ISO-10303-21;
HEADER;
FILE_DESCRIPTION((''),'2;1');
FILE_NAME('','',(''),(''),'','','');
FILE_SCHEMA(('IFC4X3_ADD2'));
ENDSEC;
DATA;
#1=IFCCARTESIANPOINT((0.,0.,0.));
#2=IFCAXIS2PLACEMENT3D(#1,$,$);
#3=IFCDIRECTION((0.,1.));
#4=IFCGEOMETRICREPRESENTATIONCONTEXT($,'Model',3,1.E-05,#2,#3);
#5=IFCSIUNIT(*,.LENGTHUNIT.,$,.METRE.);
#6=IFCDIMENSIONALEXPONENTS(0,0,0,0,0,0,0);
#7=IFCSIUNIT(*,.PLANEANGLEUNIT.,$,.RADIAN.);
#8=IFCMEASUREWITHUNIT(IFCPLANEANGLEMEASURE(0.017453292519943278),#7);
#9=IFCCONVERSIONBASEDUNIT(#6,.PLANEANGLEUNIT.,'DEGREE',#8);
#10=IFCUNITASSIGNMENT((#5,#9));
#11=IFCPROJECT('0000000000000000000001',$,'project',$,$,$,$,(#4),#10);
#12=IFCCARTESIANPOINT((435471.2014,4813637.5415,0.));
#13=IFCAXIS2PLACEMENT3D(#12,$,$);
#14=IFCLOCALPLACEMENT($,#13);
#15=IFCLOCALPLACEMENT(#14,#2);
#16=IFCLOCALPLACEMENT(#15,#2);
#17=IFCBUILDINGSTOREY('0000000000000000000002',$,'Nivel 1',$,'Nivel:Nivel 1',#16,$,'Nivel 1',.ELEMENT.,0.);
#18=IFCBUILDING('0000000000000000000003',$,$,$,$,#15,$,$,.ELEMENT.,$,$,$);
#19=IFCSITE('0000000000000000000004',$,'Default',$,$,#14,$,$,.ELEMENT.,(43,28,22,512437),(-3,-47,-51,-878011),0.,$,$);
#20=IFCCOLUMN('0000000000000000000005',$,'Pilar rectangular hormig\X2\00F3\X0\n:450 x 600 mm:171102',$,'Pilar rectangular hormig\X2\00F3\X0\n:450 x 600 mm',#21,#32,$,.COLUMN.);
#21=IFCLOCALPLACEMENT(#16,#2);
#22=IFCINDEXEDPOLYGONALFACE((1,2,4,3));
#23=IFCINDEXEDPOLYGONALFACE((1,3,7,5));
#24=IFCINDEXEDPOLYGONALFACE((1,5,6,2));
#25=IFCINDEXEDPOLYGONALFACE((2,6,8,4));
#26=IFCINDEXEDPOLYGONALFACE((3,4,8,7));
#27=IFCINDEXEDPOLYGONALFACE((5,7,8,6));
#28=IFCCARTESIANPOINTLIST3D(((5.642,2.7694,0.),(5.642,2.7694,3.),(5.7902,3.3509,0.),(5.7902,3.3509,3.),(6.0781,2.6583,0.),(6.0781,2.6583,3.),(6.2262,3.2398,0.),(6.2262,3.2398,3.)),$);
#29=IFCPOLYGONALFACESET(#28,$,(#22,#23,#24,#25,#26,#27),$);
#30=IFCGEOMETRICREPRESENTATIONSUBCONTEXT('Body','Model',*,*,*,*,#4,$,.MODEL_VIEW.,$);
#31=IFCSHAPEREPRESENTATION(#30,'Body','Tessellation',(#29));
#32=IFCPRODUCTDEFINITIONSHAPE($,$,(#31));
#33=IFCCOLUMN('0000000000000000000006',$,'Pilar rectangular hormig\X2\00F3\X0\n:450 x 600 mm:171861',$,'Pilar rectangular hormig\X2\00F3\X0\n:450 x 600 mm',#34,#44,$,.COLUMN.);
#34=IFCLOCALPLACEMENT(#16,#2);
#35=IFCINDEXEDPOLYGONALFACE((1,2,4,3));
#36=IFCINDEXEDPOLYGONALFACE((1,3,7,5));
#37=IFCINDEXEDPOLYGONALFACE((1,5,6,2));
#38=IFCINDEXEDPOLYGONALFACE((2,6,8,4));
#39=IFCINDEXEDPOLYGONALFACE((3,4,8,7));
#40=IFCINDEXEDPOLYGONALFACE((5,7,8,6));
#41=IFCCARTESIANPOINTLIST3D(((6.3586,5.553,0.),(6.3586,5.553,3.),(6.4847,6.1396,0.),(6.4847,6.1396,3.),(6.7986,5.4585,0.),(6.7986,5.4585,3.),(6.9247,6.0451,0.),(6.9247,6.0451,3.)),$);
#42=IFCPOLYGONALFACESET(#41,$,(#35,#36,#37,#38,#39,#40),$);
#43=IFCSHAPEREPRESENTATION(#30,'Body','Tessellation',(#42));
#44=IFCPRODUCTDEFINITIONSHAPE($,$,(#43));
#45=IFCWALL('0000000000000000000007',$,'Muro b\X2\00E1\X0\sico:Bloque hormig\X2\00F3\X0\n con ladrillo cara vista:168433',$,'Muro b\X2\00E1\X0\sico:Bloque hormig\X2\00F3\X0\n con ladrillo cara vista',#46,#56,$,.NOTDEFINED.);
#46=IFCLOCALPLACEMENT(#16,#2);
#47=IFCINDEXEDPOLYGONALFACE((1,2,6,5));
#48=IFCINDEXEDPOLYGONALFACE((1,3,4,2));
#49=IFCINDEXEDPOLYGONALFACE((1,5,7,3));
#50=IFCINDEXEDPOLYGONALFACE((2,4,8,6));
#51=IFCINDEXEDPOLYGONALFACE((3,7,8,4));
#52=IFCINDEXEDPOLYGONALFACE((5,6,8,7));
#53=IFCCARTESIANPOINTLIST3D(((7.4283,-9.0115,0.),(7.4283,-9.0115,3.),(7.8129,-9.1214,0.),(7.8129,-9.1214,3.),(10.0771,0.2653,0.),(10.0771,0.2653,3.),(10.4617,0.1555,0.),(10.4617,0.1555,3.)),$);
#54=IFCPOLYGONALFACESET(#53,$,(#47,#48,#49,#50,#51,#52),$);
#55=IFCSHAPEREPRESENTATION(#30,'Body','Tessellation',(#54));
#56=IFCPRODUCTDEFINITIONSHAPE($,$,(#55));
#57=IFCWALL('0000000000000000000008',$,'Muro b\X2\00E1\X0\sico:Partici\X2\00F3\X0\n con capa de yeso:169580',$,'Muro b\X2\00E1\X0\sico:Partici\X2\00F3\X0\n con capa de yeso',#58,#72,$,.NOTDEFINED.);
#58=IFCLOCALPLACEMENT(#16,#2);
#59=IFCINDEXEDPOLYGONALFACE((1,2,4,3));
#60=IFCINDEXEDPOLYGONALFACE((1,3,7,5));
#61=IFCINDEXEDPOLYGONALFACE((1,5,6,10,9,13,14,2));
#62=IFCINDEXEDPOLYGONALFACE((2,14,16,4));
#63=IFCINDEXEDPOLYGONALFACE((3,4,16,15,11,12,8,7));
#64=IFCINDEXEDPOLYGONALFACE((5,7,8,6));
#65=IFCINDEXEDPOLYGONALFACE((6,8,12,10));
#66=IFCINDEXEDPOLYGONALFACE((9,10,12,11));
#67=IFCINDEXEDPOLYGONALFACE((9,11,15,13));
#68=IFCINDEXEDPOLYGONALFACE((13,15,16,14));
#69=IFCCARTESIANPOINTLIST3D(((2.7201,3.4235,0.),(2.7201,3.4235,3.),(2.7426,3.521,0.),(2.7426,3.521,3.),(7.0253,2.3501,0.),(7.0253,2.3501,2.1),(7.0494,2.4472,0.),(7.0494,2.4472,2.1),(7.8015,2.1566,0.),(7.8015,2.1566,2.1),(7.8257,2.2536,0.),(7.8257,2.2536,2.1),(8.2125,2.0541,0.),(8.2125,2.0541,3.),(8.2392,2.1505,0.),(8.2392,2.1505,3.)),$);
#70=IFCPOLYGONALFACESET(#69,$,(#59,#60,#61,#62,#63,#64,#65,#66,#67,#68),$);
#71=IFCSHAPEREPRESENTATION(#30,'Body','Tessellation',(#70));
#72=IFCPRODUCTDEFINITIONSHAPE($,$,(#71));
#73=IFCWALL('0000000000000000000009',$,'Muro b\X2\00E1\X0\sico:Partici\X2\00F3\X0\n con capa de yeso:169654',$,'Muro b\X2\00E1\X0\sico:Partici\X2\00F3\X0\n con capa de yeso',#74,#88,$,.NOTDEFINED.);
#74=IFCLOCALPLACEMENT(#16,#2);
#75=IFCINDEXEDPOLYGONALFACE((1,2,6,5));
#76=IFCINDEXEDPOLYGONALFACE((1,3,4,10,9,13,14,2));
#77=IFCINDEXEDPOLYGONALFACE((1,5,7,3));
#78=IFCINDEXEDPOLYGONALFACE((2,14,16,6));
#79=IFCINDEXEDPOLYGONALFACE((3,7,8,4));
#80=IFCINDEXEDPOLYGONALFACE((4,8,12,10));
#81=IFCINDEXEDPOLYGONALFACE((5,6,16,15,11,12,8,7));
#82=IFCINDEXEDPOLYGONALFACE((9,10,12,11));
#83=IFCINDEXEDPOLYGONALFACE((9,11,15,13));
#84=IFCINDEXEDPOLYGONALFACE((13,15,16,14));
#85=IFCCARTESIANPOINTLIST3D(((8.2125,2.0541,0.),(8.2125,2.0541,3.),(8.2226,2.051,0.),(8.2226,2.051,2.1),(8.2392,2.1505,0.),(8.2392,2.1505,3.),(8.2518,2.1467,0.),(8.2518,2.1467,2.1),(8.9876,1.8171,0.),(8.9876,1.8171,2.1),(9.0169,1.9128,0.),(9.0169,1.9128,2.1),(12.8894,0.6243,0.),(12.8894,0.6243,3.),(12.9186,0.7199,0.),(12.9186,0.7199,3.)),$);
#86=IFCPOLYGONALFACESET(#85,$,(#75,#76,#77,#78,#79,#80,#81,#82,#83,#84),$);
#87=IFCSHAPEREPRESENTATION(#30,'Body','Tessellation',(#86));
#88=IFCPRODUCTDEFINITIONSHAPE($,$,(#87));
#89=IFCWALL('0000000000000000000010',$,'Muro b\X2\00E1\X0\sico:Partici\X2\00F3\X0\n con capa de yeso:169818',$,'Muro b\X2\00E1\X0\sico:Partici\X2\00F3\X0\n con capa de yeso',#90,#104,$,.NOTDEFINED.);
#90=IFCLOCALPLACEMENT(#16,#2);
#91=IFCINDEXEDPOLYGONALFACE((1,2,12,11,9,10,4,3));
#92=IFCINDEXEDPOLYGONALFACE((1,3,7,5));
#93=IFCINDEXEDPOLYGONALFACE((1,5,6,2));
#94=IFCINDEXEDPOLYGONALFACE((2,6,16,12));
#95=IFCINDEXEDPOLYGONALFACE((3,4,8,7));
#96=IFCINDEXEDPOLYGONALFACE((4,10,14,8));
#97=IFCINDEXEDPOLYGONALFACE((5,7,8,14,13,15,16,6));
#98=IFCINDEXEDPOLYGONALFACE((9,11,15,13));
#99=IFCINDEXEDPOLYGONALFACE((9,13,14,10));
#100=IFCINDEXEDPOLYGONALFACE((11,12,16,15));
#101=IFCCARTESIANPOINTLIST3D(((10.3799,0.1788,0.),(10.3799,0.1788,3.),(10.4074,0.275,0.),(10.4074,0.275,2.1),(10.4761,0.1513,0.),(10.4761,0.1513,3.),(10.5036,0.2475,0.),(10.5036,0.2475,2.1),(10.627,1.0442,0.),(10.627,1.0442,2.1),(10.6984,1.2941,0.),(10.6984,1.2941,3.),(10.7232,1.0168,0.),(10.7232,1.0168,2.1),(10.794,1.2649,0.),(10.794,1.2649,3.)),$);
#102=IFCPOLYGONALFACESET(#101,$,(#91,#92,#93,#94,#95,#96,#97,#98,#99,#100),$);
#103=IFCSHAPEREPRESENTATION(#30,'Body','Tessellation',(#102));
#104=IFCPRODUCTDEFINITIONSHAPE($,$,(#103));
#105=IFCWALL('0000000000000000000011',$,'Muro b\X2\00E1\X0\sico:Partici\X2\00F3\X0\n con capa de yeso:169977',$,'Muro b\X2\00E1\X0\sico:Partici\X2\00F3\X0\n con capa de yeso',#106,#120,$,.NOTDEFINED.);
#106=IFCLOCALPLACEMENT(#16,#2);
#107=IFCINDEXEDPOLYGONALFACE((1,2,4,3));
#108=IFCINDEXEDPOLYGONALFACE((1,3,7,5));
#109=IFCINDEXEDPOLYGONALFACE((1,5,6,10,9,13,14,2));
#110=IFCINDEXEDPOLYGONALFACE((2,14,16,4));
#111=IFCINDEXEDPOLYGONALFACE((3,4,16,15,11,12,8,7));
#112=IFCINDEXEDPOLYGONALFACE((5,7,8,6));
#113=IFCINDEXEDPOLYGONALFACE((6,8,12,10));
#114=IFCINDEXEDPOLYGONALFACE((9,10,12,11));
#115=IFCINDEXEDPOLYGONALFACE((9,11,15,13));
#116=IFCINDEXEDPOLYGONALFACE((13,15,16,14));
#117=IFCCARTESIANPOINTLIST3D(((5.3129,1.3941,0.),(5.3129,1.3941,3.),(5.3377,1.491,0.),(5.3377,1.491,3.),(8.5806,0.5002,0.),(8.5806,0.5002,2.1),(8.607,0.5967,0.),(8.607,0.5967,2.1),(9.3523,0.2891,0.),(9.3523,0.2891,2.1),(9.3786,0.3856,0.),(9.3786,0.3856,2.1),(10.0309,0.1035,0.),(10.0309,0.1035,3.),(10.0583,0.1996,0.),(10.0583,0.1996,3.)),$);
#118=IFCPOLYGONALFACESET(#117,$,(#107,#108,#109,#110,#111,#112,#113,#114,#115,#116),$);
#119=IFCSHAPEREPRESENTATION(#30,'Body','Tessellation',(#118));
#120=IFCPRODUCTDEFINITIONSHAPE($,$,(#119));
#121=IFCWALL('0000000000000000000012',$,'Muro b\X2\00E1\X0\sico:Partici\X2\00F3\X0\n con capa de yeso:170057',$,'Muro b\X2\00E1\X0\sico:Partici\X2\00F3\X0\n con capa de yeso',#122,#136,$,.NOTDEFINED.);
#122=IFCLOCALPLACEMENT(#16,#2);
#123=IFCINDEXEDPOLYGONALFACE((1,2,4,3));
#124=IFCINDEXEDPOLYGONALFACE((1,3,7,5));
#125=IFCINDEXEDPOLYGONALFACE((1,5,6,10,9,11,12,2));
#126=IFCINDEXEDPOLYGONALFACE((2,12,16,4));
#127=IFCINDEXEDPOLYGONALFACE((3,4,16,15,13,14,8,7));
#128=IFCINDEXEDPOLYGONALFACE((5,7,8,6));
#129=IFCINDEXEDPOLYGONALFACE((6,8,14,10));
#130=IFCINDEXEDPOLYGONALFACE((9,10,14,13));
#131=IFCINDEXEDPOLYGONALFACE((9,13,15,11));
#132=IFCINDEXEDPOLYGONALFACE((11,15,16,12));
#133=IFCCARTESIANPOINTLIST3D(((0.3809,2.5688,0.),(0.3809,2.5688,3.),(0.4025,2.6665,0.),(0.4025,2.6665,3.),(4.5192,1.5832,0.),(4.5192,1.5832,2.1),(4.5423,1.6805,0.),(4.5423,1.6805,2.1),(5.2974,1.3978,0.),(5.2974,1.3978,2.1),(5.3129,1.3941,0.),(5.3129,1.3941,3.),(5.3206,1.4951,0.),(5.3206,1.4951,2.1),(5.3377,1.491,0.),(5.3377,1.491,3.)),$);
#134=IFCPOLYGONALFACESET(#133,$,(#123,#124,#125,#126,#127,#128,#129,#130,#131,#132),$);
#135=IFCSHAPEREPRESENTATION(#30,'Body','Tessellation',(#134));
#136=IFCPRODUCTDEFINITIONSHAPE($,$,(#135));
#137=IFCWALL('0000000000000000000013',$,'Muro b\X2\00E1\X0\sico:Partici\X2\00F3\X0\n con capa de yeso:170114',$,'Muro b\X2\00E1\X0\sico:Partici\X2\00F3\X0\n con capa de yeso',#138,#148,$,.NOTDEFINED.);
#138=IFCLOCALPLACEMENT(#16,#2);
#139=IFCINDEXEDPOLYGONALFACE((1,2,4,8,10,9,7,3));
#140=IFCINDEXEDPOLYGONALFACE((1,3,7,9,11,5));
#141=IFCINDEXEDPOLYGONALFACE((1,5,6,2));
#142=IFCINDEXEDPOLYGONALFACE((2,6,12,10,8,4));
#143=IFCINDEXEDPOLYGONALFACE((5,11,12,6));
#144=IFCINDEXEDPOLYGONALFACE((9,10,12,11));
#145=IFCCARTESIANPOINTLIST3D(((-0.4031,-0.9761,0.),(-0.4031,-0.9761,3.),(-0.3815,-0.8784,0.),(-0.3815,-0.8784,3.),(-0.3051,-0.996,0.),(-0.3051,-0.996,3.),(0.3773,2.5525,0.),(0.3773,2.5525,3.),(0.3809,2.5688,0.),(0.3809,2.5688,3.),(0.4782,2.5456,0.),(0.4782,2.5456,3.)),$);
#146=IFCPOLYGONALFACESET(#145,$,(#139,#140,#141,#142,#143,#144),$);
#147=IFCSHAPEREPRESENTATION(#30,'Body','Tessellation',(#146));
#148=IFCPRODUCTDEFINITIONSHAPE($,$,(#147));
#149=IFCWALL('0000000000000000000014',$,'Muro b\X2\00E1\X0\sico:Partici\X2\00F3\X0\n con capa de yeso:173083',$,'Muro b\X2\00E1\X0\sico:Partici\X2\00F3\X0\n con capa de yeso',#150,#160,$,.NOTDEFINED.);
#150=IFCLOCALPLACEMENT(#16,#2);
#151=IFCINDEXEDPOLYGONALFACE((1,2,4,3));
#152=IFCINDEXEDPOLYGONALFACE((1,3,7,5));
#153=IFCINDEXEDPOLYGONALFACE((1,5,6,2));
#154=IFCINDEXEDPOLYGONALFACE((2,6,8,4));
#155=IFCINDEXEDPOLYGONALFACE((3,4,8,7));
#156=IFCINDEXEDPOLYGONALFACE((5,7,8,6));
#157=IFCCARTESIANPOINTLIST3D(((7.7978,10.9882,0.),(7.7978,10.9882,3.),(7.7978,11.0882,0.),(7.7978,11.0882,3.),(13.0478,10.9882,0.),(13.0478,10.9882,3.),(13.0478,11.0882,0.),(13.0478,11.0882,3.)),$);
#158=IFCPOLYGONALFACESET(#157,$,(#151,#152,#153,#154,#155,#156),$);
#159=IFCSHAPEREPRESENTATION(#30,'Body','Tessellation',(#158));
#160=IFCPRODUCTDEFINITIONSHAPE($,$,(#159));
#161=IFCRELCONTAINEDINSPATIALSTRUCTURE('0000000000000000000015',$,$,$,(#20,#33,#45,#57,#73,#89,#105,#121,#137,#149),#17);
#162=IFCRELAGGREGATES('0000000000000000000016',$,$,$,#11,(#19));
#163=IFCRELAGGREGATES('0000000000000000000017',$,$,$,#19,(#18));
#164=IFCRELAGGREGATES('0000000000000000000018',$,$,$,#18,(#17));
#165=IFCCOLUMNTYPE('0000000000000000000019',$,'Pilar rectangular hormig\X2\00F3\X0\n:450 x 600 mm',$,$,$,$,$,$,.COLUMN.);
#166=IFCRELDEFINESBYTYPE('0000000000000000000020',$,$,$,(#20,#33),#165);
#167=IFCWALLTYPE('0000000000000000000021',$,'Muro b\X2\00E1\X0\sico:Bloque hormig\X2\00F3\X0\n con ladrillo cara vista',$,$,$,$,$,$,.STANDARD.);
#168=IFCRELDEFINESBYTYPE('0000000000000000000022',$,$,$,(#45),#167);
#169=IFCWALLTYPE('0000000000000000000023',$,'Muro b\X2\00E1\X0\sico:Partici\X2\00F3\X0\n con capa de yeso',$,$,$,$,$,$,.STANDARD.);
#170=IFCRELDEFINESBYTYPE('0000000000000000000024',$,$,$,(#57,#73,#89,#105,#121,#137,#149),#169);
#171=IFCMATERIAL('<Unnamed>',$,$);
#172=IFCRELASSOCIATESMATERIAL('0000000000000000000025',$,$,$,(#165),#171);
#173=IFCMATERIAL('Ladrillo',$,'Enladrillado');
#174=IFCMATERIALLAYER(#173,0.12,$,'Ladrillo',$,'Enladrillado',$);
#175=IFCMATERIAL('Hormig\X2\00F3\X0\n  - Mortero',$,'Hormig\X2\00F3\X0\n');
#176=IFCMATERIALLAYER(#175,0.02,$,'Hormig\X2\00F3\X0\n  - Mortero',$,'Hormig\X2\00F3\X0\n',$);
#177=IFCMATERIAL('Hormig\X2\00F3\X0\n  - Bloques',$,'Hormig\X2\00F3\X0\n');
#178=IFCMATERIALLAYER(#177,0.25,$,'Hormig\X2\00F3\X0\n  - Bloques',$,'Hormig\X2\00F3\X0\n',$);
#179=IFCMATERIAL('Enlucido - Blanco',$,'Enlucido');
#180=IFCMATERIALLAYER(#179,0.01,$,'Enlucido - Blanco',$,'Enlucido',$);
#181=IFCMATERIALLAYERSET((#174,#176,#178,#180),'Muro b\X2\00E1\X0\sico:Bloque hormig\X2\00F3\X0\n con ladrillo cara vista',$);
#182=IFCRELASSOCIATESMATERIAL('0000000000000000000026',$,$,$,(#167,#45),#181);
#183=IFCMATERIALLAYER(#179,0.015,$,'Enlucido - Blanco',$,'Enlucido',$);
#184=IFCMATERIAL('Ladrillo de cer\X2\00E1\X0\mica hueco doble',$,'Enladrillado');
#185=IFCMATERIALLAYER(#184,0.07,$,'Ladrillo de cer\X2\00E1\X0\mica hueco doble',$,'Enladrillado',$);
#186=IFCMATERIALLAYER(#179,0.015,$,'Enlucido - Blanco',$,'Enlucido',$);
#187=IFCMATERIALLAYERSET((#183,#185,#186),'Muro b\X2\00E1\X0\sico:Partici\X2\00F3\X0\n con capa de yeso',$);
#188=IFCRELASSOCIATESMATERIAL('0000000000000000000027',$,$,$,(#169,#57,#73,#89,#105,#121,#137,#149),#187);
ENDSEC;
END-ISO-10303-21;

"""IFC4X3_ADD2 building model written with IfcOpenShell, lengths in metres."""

from ifc_helpers import new_model, entity, si_unit, converted_unit, direction, frame, frame_2d, origin, origin_2d_with_axis, place, context, subcontext, project, spatial, polyline, rectangle, outline, extrude, source, transform, mapped, material, layer, layer_set, material_profile, profile_set, type_object, type_shapes, element, save


model = new_model("IFC4X3_ADD2")

# Units and contexts
model_context = context("Model", 3, precision=1e-05, world=origin(), true_north=direction((0.0, 1.0)))
body_context = subcontext(model_context, "Body", "Model", "MODEL_VIEW")
ifc_project = project(units=[si_unit("LENGTHUNIT", "METRE"), converted_unit("PLANEANGLEUNIT", "DEGREE", entity("IfcPlaneAngleMeasure", 0.017453292519943278), si_unit("PLANEANGLEUNIT", "RADIAN"), dimensions=[0, 0, 0, 0, 0, 0, 0])], contexts=[model_context])

# Site, building, storey
site_placement = place(None, frame((435471.2014, 4813637.5415, 0.0)))
site = spatial("IfcSite", under=ifc_project, at=site_placement, Name="Default", CompositionType="ELEMENT", RefLatitude=(43, 28, 22, 512437), RefLongitude=(-3, -47, -51, -878011), RefElevation=0.0)
building_placement = place(site_placement, origin())
building = spatial("IfcBuilding", under=site, at=building_placement, CompositionType="ELEMENT")
storey_placement = place(building_placement, origin())
storey = spatial("IfcBuildingStorey", under=building, at=storey_placement, Name="Nivel 1", ObjectType="Nivel:Nivel 1", LongName="Nivel 1", CompositionType="ELEMENT", Elevation=0.0)

# Columns
ifc_material_1 = material(Name="<Unnamed>")
ifc_material_profile = material_profile(ifc_material_1, rectangle(XDim=0.45, YDim=0.6, at=origin_2d_with_axis()), Name="450 x 600 mm")
ifc_profile_set = profile_set([ifc_material_profile], Name="450 x 600 mm")
column_type = type_object("IfcColumnType", Name="Pilar rectangular hormigón:450 x 600 mm", PredefinedType="COLUMN", material=ifc_profile_set)
shared_shape = source(origin(), body_context, "Body", "SweptSolid", [
    extrude(rectangle(XDim=0.45, YDim=0.6, at=origin_2d_with_axis()), frame((0.0, 0.0, 0.0), z_axis=(0.0, 0.0, 1.0), x_axis=(-1.0, 0.0, 0.0)), (0.0, 0.0, 1.0), 3.0),
])
type_shapes(column_type, [shared_shape])
for number, where, z_axis, x_axis, name in (
    (1, (5.9341, 3.0046, 0.0), (0.0, 0.0, 1.0), (0.969039, -0.246908, 0.0), "Pilar rectangular hormigón:450 x 600 mm:171102"),
    (2, (6.6416, 5.799, 0.0), (0.0, 0.0, 1.0), (0.977667, -0.210159, 0.0), "Pilar rectangular hormigón:450 x 600 mm:171861"),
):
    element("IfcColumn", number, at=place(storey_placement, frame(where, z_axis=z_axis, x_axis=x_axis)), inside=storey, type_object=column_type, Name=name, ObjectType="Pilar rectangular hormigón:450 x 600 mm", PredefinedType="COLUMN", context=body_context, shape_type="MappedRepresentation", body=[
        mapped(shared_shape, transform((0.0, 0.0, 0.0), scale=1.0)),
    ])

# Shared definitions
ifc_material_2 = material(Name="Enlucido - Blanco", Category="Enlucido")

# Wall
ifc_material_3 = material(Name="Ladrillo", Category="Enladrillado")
ifc_layer_1 = layer(ifc_material_3, 0.12, Name="Ladrillo", Category="Enladrillado")
ifc_material_4 = material(Name="Hormigón  - Mortero", Category="Hormigón")
ifc_layer_2 = layer(ifc_material_4, 0.02, Name="Hormigón  - Mortero", Category="Hormigón")
ifc_material_5 = material(Name="Hormigón  - Bloques", Category="Hormigón")
ifc_layer_3 = layer(ifc_material_5, 0.25, Name="Hormigón  - Bloques", Category="Hormigón")
ifc_layer_4 = layer(ifc_material_2, 0.01, Name="Enlucido - Blanco", Category="Enlucido")
ifc_layer_set_1 = layer_set([ifc_layer_1, ifc_layer_2, ifc_layer_3, ifc_layer_4], Name="Muro básico:Bloque hormigón con ladrillo cara vista")
wall_type_1 = type_object("IfcWallType", Name="Muro básico:Bloque hormigón con ladrillo cara vista", PredefinedType="STANDARD", material=ifc_layer_set_1)
wall_1_placement = place(storey_placement, frame((10.2694, 0.2104, 0.0), z_axis=(0.0, 0.0, 1.0), x_axis=(-0.274552, -0.961572, 0.0)))
element("IfcWall", 3, at=wall_1_placement, inside=storey, type_object=wall_type_1, material=ifc_layer_set_1, Name="Muro básico:Bloque hormigón con ladrillo cara vista:168433", ObjectType="Muro básico:Bloque hormigón con ladrillo cara vista", PredefinedType="NOTDEFINED", context=body_context, shape_type="SweptSolid", body=[
    extrude(rectangle(XDim=9.6476, YDim=0.4, at=frame_2d((4.8238, 0.0), x_axis=(-1.0, 0.0))), origin(), (0.0, 0.0, 1.0), 3.0),
])

# Walls, openings
ifc_layer_5 = layer(ifc_material_2, 0.015, Name="Enlucido - Blanco", Category="Enlucido")
ifc_material_6 = material(Name="Ladrillo de cerámica hueco doble", Category="Enladrillado")
ifc_layer_6 = layer(ifc_material_6, 0.07, Name="Ladrillo de cerámica hueco doble", Category="Enladrillado")
ifc_layer_7 = layer(ifc_material_2, 0.015, Name="Enlucido - Blanco", Category="Enlucido")
ifc_layer_set_2 = layer_set([ifc_layer_5, ifc_layer_6, ifc_layer_7], Name="Muro básico:Partición con capa de yeso")
wall_type_2 = type_object("IfcWallType", Name="Muro básico:Partición con capa de yeso", PredefinedType="STANDARD", material=ifc_layer_set_2)
wall_2_placement = place(storey_placement, frame((2.7305, 3.4725, 0.0), z_axis=(0.0, 0.0, 1.0), x_axis=(0.970296, -0.241922, 0.0)))
wall_2 = element("IfcWall", 4, at=wall_2_placement, inside=storey, type_object=wall_type_2, material=ifc_layer_set_2, Name="Muro básico:Partición con capa de yeso:169580", ObjectType="Muro básico:Partición con capa de yeso", PredefinedType="NOTDEFINED", context=body_context, shape_type="SweptSolid", body=[
    extrude(outline(polyline([(0.0018, -0.05), (5.6622, -0.05), (5.6648, 0.05), (5.4827, 0.05), (5.3826, 0.05), (0.4693, 0.05), (0.3693, 0.05), (0.0, 0.05), (0.0018, -0.05)])), origin(), (0.0, 0.0, 1.0), 3.0),
])
opening_1_placement = place(wall_2_placement, frame((4.4387, -0.05, 0.0)))
element("IfcOpeningElement", 5, at=opening_1_placement, cuts=wall_2, PredefinedType="OPENING", context=body_context, shape_type="SweptSolid", body=[
    extrude(rectangle(XDim=2.1, YDim=0.8, at=frame_2d((1.05, 0.4), x_axis=(1.0, 0.0))), frame((0.0, 0.0, 0.0), z_axis=(0.0, 1.0, 0.0), x_axis=(0.0, 0.0, 1.0)), (0.0, 0.0, 1.0), 0.1),
])
wall_3_placement = place(storey_placement, frame((8.2246, 2.1027, 0.0), z_axis=(0.0, 0.0, 1.0), x_axis=(0.956305, -0.292372, 0.0)))
wall_3 = element("IfcWall", 6, at=wall_3_placement, inside=storey, type_object=wall_type_2, material=ifc_layer_set_2, Name="Muro básico:Partición con capa de yeso:169654", ObjectType="Muro básico:Partición con capa de yeso", PredefinedType="NOTDEFINED", context=body_context, shape_type="SweptSolid", body=[
    extrude(outline(polyline([(0.0026, -0.05), (2.6022, -0.05), (2.7022, -0.05), (4.8932, -0.05), (4.8932, 0.05), (0.0, 0.05), (0.0026, -0.05)])), origin(), (0.0, 0.0, 1.0), 3.0),
])
opening_2_placement = place(wall_3_placement, frame((0.0132, -0.05, 0.0)))
element("IfcOpeningElement", 7, at=opening_2_placement, cuts=wall_3, PredefinedType="OPENING", context=body_context, shape_type="SweptSolid", body=[
    extrude(rectangle(XDim=2.1, YDim=0.8, at=frame_2d((1.05, 0.4), x_axis=(1.0, 0.0))), frame((0.0, 0.0, 0.0), z_axis=(0.0, 1.0, 0.0), x_axis=(0.0, 0.0, 1.0)), (0.0, 0.0, 1.0), 0.1),
])
wall_4_placement = place(storey_placement, frame((10.7465, 1.2804, 0.0), z_axis=(0.0, 0.0, 1.0), x_axis=(-0.274552, -0.961572, 0.0)))
wall_4 = element("IfcWall", 8, at=wall_4_placement, inside=storey, type_object=wall_type_2, material=ifc_layer_set_2, Name="Muro básico:Partición con capa de yeso:169818", ObjectType="Muro básico:Partición con capa de yeso", PredefinedType="NOTDEFINED", context=body_context, shape_type="SweptSolid", body=[
    extrude(outline(polyline([(0.0, -0.05), (1.1599, -0.05), (1.1599, 0.035), (1.1599, 0.05), (0.0019, 0.05), (0.0, -0.05)])), origin(), (0.0, 0.0, 1.0), 3.0),
])
opening_3_placement = place(wall_4_placement, frame((0.2599, -0.05, 0.0)))
element("IfcOpeningElement", 9, at=opening_3_placement, cuts=wall_4, PredefinedType="OPENING", context=body_context, shape_type="SweptSolid", body=[
    extrude(rectangle(XDim=2.1, YDim=0.8, at=frame_2d((1.05, 0.4), x_axis=(1.0, 0.0))), frame((0.0, 0.0, 0.0), z_axis=(0.0, 1.0, 0.0), x_axis=(0.0, 0.0, 1.0)), (0.0, 0.0, 1.0), 0.1),
])
wall_5_placement = place(storey_placement, frame((10.0451, 0.1514, 0.0), z_axis=(0.0, 0.0, 1.0), x_axis=(-0.964559, 0.263866, 0.0)))
wall_5 = element("IfcWall", 10, at=wall_5_placement, inside=storey, type_object=wall_type_2, material=ifc_layer_set_2, Name="Muro básico:Partición con capa de yeso:169977", ObjectType="Muro básico:Partición con capa de yeso", PredefinedType="NOTDEFINED", context=body_context, shape_type="SweptSolid", body=[
    extrude(outline(polyline([(0.0, -0.05), (4.8941, -0.05), (4.8925, 0.05), (0.0011, 0.05), (0.0, -0.05)])), origin(), (0.0, 0.0, 1.0), 3.0),
])
opening_4_placement = place(wall_5_placement, frame((0.7046, -0.05, 0.0)))
element("IfcOpeningElement", 11, at=opening_4_placement, cuts=wall_5, PredefinedType="OPENING", context=body_context, shape_type="SweptSolid", body=[
    extrude(rectangle(XDim=2.1, YDim=0.8, at=frame_2d((1.05, 0.4), x_axis=(1.0, 0.0))), frame((0.0, 0.0, 0.0), z_axis=(0.0, 1.0, 0.0), x_axis=(0.0, 0.0, 1.0)), (0.0, 0.0, 1.0), 0.1),
])
wall_6_placement = place(storey_placement, frame((5.3261, 1.4424, 0.0), z_axis=(0.0, 0.0, 1.0), x_axis=(-0.972789, 0.231693, 0.0)))
wall_6 = element("IfcWall", 12, at=wall_6_placement, inside=storey, type_object=wall_type_2, material=ifc_layer_set_2, Name="Muro básico:Partición con capa de yeso:170057", ObjectType="Muro básico:Partición con capa de yeso", PredefinedType="NOTDEFINED", context=body_context, shape_type="SweptSolid", body=[
    extrude(outline(polyline([(0.0, -0.05), (5.0732, -0.05), (5.0729, -0.0333), (5.0716, 0.05), (4.9716, 0.05), (0.0017, 0.05), (0.0, -0.05)])), origin(), (0.0, 0.0, 1.0), 3.0),
])
opening_5_placement = place(wall_6_placement, frame((0.0176, -0.05, 0.0)))
element("IfcOpeningElement", 13, at=opening_5_placement, cuts=wall_6, PredefinedType="OPENING", context=body_context, shape_type="SweptSolid", body=[
    extrude(rectangle(XDim=2.1, YDim=0.8, at=frame_2d((1.05, 0.4), x_axis=(1.0, 0.0))), frame((0.0, 0.0, 0.0), z_axis=(0.0, 1.0, 0.0), x_axis=(0.0, 0.0, 1.0)), (0.0, 0.0, 1.0), 0.1),
])

# Walls
wall_7_placement = place(storey_placement, frame((0.4297, 2.558, 0.0), z_axis=(0.0, 0.0, 1.0), x_axis=(-0.215934, -0.976408, 0.0)))
element("IfcWall", 14, at=wall_7_placement, inside=storey, type_object=wall_type_2, material=ifc_layer_set_2, Name="Muro básico:Partición con capa de yeso:170114", ObjectType="Muro básico:Partición con capa de yeso", PredefinedType="NOTDEFINED", context=body_context, shape_type="SweptSolid", body=[
    extrude(outline(polyline([(3.6305, -0.05), (3.6289, 0.05), (0.0016, 0.05), (0.0, -0.05), (0.0167, -0.05), (3.5305, -0.05), (3.6305, -0.05)])), origin(), (0.0, 0.0, 1.0), 3.0),
])
wall_8_placement = place(storey_placement, frame((7.7978, 11.0382, 0.0)))
element("IfcWall", 15, at=wall_8_placement, inside=storey, type_object=wall_type_2, material=ifc_layer_set_2, Name="Muro básico:Partición con capa de yeso:173083", ObjectType="Muro básico:Partición con capa de yeso", PredefinedType="NOTDEFINED", context=body_context, shape_type="SweptSolid", body=[
    extrude(rectangle(XDim=5.25, YDim=0.1, at=frame_2d((2.625, 0.0), x_axis=(-1.0, 0.0))), origin(), (0.0, 0.0, 1.0), 3.0),
])

save(model, "model.ifc")
